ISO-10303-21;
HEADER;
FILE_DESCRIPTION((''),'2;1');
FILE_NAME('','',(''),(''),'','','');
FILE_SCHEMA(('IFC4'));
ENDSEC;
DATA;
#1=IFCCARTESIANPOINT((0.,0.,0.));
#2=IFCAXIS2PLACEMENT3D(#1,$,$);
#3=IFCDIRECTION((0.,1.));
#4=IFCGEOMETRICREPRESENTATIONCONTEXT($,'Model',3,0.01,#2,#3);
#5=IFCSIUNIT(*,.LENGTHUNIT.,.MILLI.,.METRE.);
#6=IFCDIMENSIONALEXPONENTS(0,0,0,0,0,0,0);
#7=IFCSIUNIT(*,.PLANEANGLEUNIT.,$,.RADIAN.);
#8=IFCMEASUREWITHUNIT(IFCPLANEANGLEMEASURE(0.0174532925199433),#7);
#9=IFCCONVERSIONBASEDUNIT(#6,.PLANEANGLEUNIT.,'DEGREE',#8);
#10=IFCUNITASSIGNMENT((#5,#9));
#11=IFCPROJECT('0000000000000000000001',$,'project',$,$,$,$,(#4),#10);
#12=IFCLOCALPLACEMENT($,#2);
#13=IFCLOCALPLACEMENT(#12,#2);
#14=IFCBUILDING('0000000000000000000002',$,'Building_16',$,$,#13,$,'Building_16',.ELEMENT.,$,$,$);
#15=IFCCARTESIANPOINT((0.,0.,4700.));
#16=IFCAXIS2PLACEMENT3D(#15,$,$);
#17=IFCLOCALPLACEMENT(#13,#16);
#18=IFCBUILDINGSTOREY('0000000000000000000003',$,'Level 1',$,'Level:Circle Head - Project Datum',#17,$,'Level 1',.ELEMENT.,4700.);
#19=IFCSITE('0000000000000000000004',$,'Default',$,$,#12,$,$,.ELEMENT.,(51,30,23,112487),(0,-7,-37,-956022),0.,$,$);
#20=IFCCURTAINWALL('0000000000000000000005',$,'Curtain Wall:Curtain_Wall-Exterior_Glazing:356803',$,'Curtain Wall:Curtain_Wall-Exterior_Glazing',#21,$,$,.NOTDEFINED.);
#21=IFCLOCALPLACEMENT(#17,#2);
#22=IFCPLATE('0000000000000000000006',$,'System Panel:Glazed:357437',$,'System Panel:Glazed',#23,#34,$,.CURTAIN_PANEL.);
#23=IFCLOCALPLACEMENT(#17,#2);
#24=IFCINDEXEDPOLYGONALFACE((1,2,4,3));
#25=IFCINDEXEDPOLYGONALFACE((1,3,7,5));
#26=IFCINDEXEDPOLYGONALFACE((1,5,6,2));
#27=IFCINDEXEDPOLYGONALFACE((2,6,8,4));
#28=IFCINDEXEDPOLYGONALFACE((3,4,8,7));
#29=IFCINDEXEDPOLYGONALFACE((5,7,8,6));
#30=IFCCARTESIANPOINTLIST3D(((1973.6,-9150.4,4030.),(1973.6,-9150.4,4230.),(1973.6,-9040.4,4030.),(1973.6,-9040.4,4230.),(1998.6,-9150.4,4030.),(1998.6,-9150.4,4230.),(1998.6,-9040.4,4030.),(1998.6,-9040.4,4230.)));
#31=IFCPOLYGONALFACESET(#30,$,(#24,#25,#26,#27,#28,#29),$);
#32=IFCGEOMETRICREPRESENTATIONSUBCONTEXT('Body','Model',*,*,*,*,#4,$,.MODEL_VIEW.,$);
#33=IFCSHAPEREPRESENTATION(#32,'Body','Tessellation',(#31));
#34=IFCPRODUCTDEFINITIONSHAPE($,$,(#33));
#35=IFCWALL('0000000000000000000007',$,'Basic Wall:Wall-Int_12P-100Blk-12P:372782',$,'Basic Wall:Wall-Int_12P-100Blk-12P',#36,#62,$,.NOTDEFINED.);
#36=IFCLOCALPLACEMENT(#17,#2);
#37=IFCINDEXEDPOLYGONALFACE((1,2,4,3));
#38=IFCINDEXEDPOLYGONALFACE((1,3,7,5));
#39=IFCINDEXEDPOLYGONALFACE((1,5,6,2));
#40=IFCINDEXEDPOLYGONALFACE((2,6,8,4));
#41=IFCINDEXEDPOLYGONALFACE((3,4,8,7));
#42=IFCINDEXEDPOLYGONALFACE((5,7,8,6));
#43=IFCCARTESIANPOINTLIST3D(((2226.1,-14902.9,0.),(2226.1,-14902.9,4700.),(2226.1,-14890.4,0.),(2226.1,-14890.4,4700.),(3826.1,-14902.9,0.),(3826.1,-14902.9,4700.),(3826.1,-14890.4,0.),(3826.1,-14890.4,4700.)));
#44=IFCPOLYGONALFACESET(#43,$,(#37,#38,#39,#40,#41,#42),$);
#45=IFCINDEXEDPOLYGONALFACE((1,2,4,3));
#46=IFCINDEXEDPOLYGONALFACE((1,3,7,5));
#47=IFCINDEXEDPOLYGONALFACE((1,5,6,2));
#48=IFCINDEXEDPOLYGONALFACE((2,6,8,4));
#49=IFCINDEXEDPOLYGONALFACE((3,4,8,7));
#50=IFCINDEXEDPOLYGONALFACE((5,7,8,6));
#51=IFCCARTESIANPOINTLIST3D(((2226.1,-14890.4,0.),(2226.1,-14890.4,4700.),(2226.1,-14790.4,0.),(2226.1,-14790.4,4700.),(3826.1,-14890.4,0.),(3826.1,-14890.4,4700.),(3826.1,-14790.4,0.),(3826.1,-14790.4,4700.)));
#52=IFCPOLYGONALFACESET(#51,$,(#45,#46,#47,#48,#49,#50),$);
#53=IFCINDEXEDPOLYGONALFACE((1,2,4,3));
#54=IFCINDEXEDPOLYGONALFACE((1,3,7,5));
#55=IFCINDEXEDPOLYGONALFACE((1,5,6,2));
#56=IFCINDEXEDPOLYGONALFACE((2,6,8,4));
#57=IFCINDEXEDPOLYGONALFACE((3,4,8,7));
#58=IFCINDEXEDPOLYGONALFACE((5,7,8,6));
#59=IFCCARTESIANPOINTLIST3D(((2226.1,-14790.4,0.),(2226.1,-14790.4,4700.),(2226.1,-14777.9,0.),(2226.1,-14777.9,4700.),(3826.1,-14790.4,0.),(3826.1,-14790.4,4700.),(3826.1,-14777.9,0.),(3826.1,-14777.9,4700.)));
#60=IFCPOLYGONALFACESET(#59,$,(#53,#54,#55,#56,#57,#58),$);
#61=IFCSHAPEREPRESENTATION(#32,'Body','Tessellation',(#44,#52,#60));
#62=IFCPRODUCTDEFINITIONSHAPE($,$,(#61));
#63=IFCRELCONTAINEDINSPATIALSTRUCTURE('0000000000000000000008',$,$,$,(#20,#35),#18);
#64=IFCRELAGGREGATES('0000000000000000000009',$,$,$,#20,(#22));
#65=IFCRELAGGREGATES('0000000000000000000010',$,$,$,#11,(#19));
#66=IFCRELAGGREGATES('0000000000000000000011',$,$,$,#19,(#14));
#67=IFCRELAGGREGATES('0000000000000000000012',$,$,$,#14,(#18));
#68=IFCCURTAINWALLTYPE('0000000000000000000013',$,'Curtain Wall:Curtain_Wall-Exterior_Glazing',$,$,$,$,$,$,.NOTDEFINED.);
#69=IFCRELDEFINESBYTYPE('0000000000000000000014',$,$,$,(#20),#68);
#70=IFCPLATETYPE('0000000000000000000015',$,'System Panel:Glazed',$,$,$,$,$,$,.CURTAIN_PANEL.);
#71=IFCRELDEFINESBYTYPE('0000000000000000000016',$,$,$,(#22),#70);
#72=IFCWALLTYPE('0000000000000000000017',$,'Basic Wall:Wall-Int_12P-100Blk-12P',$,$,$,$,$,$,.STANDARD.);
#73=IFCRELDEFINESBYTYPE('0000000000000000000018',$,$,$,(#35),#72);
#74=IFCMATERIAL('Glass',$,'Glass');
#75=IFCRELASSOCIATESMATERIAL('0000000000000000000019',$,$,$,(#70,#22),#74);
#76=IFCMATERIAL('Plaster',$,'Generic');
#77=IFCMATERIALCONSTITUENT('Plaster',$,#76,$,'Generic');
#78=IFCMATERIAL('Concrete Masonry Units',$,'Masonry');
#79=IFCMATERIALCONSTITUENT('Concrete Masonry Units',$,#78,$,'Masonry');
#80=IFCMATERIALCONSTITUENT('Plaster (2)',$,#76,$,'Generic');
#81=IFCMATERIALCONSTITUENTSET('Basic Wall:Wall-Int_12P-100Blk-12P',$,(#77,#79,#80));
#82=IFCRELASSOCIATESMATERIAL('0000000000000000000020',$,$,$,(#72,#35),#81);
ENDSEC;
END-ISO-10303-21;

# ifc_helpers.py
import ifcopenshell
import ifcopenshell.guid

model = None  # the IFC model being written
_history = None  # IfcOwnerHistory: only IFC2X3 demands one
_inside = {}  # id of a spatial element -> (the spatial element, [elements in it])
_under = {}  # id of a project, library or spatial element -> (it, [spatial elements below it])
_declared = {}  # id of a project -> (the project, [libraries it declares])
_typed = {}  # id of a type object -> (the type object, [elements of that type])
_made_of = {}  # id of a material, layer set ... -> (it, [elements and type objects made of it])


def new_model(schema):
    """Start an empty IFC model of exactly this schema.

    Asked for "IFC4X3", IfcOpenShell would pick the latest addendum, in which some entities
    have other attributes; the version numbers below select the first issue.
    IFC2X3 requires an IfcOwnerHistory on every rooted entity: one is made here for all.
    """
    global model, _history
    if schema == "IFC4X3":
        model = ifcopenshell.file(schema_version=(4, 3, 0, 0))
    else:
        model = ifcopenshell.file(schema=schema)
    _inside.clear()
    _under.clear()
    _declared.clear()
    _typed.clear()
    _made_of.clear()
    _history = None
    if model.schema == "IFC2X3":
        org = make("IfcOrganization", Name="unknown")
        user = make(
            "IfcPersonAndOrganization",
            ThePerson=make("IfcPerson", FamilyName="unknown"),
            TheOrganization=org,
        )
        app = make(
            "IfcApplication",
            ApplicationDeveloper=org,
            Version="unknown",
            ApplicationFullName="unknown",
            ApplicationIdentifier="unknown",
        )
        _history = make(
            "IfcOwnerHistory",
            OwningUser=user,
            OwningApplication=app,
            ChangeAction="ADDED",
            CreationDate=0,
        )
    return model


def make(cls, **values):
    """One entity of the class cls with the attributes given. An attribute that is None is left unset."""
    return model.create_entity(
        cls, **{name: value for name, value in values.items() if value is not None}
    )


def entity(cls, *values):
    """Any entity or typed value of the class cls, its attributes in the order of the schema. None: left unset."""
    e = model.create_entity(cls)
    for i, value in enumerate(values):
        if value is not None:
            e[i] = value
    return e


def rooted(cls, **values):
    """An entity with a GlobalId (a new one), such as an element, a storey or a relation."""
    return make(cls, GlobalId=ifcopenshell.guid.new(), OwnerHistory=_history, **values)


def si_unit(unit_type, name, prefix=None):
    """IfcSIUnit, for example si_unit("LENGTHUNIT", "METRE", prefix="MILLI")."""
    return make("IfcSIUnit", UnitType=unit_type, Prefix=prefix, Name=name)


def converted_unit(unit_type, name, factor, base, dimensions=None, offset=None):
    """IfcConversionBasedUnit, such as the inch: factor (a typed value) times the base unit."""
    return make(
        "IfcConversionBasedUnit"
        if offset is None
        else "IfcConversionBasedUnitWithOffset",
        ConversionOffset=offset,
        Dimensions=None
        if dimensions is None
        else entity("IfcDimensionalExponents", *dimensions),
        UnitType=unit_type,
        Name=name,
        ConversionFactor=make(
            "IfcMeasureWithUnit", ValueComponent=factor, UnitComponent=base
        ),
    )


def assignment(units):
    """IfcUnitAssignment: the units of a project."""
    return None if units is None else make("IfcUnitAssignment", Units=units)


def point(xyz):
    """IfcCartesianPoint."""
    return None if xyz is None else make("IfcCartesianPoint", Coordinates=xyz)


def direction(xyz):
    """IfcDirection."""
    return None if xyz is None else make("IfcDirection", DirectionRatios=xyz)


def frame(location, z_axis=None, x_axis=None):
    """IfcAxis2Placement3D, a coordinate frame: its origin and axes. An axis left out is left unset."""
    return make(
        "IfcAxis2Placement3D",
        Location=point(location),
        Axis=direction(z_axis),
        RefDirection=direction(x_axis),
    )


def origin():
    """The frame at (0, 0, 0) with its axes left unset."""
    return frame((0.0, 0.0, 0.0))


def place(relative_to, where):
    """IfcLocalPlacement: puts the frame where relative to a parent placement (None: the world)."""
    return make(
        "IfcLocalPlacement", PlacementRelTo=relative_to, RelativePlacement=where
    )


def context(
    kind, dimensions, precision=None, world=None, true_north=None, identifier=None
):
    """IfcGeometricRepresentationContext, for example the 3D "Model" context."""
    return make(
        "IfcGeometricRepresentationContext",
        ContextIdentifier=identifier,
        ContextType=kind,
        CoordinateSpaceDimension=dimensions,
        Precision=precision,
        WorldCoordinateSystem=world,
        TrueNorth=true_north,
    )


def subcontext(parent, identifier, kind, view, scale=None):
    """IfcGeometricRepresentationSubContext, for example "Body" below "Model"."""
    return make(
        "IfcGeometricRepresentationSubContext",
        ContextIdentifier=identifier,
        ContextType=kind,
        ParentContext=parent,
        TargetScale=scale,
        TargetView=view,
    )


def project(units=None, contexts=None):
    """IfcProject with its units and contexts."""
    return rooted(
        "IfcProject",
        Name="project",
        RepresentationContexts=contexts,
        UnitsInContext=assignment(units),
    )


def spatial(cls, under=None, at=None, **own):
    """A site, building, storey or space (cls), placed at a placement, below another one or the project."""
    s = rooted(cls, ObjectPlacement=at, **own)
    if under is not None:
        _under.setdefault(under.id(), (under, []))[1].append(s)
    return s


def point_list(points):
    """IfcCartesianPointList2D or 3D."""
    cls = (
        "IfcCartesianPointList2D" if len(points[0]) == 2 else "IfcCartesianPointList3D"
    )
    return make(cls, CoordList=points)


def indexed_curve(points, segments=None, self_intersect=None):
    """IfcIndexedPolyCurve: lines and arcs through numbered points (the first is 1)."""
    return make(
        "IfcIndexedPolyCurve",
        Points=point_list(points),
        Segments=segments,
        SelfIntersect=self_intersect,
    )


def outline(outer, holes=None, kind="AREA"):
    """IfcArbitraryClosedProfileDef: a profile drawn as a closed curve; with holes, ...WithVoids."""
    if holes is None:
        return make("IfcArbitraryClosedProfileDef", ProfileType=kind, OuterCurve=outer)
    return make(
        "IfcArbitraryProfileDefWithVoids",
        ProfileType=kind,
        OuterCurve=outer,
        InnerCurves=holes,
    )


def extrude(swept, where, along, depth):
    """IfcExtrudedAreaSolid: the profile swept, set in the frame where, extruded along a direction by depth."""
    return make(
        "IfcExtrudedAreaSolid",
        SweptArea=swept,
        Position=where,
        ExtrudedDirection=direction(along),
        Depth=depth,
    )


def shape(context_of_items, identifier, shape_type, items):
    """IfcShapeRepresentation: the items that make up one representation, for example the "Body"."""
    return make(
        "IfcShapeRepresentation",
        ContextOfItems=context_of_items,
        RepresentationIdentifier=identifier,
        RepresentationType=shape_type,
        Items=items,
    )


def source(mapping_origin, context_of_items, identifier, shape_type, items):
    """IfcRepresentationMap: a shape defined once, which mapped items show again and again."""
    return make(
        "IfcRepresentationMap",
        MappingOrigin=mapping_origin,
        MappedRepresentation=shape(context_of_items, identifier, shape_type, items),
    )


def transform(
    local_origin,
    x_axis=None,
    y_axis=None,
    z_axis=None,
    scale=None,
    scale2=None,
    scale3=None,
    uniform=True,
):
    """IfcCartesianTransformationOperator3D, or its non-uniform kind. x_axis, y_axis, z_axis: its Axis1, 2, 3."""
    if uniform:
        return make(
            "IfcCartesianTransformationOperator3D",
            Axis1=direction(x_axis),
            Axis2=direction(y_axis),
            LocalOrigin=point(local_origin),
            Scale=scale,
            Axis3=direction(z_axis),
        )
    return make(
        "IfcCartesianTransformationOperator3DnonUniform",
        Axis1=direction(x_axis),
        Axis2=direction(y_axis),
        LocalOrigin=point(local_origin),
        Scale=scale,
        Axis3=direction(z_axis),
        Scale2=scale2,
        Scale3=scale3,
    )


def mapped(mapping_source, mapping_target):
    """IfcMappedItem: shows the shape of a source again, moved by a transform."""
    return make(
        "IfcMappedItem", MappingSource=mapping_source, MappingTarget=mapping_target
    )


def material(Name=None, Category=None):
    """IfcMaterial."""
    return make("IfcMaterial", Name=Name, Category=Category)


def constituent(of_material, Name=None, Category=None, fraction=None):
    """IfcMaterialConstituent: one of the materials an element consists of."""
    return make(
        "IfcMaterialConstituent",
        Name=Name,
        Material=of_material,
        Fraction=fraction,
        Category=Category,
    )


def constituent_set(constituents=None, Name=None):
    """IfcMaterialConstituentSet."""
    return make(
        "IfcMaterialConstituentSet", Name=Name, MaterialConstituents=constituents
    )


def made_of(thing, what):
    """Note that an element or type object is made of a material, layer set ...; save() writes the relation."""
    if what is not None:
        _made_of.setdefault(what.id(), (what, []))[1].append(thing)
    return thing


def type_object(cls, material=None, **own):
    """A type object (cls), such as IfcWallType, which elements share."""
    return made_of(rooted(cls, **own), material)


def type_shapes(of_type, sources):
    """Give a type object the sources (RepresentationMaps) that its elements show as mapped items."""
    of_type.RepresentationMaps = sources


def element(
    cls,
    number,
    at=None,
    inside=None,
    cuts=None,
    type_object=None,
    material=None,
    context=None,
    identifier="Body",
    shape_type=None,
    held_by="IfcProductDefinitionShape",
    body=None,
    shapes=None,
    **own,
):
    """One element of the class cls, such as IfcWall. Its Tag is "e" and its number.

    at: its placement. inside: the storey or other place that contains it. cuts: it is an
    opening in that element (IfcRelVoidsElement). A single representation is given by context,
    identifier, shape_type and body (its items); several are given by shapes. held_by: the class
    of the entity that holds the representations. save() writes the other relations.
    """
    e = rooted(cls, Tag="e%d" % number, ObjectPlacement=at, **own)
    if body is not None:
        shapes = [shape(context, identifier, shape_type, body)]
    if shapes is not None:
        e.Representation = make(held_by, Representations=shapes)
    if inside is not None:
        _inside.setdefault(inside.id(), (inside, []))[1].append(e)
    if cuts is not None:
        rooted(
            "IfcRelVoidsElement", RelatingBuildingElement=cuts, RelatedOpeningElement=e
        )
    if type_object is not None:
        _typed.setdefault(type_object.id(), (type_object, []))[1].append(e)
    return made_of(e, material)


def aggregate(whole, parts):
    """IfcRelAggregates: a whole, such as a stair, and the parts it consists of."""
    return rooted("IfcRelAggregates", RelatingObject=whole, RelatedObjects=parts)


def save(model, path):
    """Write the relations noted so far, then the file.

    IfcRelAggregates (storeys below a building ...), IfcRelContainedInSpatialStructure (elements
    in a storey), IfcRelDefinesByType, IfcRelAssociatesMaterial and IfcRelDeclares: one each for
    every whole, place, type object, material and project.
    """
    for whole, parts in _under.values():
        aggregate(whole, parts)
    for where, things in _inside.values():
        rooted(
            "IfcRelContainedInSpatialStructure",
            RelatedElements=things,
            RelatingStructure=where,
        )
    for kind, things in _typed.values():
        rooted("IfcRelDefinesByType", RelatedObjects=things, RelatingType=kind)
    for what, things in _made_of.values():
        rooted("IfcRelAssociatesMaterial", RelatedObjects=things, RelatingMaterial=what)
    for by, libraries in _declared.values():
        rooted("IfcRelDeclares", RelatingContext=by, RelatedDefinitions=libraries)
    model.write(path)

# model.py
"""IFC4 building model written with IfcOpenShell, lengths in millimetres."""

from ifc_helpers import new_model, entity, si_unit, converted_unit, direction, frame, origin, place, context, subcontext, project, spatial, indexed_curve, outline, extrude, source, transform, mapped, material, constituent, constituent_set, type_object, type_shapes, element, aggregate, save


model = new_model("IFC4")

# Units and contexts
model_context = context("Model", 3, precision=0.01, world=origin(), true_north=direction((0.0, 1.0)))
body_context = subcontext(model_context, "Body", "Model", "MODEL_VIEW")
ifc_project = project(units=[si_unit("LENGTHUNIT", "METRE", prefix="MILLI"), converted_unit("PLANEANGLEUNIT", "DEGREE", entity("IfcPlaneAngleMeasure", 0.0174532925199433), si_unit("PLANEANGLEUNIT", "RADIAN"), dimensions=[0, 0, 0, 0, 0, 0, 0])], contexts=[model_context])

# Site, building, storey
site_placement = place(None, origin())
site = spatial("IfcSite", under=ifc_project, at=site_placement, Name="Default", CompositionType="ELEMENT", RefLatitude=(51, 30, 23, 112487), RefLongitude=(0, -7, -37, -956022), RefElevation=0.0)
building_placement = place(site_placement, origin())
building = spatial("IfcBuilding", under=site, at=building_placement, Name="Building_16", LongName="Building_16", CompositionType="ELEMENT")
storey_placement = place(building_placement, frame((0.0, 0.0, 4700.0)))
storey = spatial("IfcBuildingStorey", under=building, at=storey_placement, Name="Level 1", ObjectType="Level:Circle Head - Project Datum", LongName="Level 1", CompositionType="ELEMENT", Elevation=4700.0)

# Curtain wall
curtain_wall_type = type_object("IfcCurtainWallType", Name="Curtain Wall:Curtain_Wall-Exterior_Glazing", PredefinedType="NOTDEFINED")
curtain_wall_1_placement = place(storey_placement, frame((0.0, 0.0, -4700.0)))
curtain_wall_1 = element("IfcCurtainWall", 1, at=curtain_wall_1_placement, inside=storey, type_object=curtain_wall_type, Name="Curtain Wall:Curtain_Wall-Exterior_Glazing:356803", ObjectType="Curtain Wall:Curtain_Wall-Exterior_Glazing", PredefinedType="NOTDEFINED")
ifc_material_1 = material(Name="Glass", Category="Glass")

# Plate
plate_type_1 = type_object("IfcPlateType", Name="System Panel:Glazed", PredefinedType="CURTAIN_PANEL", material=ifc_material_1)
shared_shape_1 = source(origin(), body_context, "Body", "SweptSolid", [
    extrude(outline(indexed_curve([(-12.5, -55.0), (12.5, -55.0), (12.5, 55.0), (-12.5, 55.0), (-12.5, -55.0)], self_intersect=False)), frame((0.0, 37.0, 0.0), z_axis=(0.0, 0.0, 1.0), x_axis=(0.0, 1.0, 0.0)), (0.0, 0.0, 1.0), 200.0),
])
type_shapes(plate_type_1, [shared_shape_1])
plate_1_placement = place(curtain_wall_1_placement, frame((2023.1, -9095.4, 8730.0), z_axis=(0.0, 0.0, 1.0), x_axis=(0.0, 1.0, 0.0)))
plate_1 = element("IfcPlate", 2, at=plate_1_placement, type_object=plate_type_1, material=ifc_material_1, Name="System Panel:Glazed:357437", ObjectType="System Panel:Glazed", PredefinedType="CURTAIN_PANEL", context=body_context, shape_type="MappedRepresentation", body=[
    mapped(shared_shape_1, transform((0.0, 0.0, 0.0), scale=1.0)),
])
aggregate(curtain_wall_1, [plate_1])

# Wall
ifc_material_2 = material(Name="Plaster", Category="Generic")
ifc_constituent_1 = constituent(ifc_material_2, Name="Plaster", Category="Generic")
ifc_material_3 = material(Name="Concrete Masonry Units", Category="Masonry")
ifc_constituent_2 = constituent(ifc_material_3, Name="Concrete Masonry Units", Category="Masonry")
ifc_constituent_3 = constituent(ifc_material_2, Name="Plaster (2)", Category="Generic")
ifc_constituent_set = constituent_set(constituents=[ifc_constituent_1, ifc_constituent_2, ifc_constituent_3], Name="Basic Wall:Wall-Int_12P-100Blk-12P")
wall_type = type_object("IfcWallType", Name="Basic Wall:Wall-Int_12P-100Blk-12P", PredefinedType="STANDARD", material=ifc_constituent_set)
wall_placement = place(storey_placement, frame((2226.1, -14840.4, 0.0)))
element("IfcWall", 3, at=wall_placement, inside=storey, type_object=wall_type, material=ifc_constituent_set, Name="Basic Wall:Wall-Int_12P-100Blk-12P:372782", ObjectType="Basic Wall:Wall-Int_12P-100Blk-12P", PredefinedType="NOTDEFINED", context=body_context, shape_type="SweptSolid", body=[
    extrude(outline(indexed_curve([(-6.3, -800.0), (6.2, -800.0), (6.3, 800.0), (-6.2, 800.0), (-6.3, -800.0)], self_intersect=False)), frame((800.0, -56.3, 0.0), z_axis=(0.0, 0.0, 1.0), x_axis=(0.0, 1.0, 0.0)), (0.0, 0.0, 1.0), 4700.0),
    extrude(outline(indexed_curve([(-800.0, -50.0), (800.0, -50.0), (800.0, 50.0), (-800.0, 50.0), (-800.0, -50.0)], self_intersect=False)), frame((800.0, 0.0, 0.0)), (0.0, 0.0, 1.0), 4700.0),
    extrude(outline(indexed_curve([(-6.3, -800.0), (6.2, -800.0), (6.3, 800.0), (-6.2, 800.0), (-6.3, -800.0)], self_intersect=False)), frame((800.0, 56.3, 0.0), z_axis=(0.0, 0.0, 1.0), x_axis=(0.0, -1.0, 0.0)), (0.0, 0.0, 1.0), 4700.0),
])

save(model, "model.ifc")
